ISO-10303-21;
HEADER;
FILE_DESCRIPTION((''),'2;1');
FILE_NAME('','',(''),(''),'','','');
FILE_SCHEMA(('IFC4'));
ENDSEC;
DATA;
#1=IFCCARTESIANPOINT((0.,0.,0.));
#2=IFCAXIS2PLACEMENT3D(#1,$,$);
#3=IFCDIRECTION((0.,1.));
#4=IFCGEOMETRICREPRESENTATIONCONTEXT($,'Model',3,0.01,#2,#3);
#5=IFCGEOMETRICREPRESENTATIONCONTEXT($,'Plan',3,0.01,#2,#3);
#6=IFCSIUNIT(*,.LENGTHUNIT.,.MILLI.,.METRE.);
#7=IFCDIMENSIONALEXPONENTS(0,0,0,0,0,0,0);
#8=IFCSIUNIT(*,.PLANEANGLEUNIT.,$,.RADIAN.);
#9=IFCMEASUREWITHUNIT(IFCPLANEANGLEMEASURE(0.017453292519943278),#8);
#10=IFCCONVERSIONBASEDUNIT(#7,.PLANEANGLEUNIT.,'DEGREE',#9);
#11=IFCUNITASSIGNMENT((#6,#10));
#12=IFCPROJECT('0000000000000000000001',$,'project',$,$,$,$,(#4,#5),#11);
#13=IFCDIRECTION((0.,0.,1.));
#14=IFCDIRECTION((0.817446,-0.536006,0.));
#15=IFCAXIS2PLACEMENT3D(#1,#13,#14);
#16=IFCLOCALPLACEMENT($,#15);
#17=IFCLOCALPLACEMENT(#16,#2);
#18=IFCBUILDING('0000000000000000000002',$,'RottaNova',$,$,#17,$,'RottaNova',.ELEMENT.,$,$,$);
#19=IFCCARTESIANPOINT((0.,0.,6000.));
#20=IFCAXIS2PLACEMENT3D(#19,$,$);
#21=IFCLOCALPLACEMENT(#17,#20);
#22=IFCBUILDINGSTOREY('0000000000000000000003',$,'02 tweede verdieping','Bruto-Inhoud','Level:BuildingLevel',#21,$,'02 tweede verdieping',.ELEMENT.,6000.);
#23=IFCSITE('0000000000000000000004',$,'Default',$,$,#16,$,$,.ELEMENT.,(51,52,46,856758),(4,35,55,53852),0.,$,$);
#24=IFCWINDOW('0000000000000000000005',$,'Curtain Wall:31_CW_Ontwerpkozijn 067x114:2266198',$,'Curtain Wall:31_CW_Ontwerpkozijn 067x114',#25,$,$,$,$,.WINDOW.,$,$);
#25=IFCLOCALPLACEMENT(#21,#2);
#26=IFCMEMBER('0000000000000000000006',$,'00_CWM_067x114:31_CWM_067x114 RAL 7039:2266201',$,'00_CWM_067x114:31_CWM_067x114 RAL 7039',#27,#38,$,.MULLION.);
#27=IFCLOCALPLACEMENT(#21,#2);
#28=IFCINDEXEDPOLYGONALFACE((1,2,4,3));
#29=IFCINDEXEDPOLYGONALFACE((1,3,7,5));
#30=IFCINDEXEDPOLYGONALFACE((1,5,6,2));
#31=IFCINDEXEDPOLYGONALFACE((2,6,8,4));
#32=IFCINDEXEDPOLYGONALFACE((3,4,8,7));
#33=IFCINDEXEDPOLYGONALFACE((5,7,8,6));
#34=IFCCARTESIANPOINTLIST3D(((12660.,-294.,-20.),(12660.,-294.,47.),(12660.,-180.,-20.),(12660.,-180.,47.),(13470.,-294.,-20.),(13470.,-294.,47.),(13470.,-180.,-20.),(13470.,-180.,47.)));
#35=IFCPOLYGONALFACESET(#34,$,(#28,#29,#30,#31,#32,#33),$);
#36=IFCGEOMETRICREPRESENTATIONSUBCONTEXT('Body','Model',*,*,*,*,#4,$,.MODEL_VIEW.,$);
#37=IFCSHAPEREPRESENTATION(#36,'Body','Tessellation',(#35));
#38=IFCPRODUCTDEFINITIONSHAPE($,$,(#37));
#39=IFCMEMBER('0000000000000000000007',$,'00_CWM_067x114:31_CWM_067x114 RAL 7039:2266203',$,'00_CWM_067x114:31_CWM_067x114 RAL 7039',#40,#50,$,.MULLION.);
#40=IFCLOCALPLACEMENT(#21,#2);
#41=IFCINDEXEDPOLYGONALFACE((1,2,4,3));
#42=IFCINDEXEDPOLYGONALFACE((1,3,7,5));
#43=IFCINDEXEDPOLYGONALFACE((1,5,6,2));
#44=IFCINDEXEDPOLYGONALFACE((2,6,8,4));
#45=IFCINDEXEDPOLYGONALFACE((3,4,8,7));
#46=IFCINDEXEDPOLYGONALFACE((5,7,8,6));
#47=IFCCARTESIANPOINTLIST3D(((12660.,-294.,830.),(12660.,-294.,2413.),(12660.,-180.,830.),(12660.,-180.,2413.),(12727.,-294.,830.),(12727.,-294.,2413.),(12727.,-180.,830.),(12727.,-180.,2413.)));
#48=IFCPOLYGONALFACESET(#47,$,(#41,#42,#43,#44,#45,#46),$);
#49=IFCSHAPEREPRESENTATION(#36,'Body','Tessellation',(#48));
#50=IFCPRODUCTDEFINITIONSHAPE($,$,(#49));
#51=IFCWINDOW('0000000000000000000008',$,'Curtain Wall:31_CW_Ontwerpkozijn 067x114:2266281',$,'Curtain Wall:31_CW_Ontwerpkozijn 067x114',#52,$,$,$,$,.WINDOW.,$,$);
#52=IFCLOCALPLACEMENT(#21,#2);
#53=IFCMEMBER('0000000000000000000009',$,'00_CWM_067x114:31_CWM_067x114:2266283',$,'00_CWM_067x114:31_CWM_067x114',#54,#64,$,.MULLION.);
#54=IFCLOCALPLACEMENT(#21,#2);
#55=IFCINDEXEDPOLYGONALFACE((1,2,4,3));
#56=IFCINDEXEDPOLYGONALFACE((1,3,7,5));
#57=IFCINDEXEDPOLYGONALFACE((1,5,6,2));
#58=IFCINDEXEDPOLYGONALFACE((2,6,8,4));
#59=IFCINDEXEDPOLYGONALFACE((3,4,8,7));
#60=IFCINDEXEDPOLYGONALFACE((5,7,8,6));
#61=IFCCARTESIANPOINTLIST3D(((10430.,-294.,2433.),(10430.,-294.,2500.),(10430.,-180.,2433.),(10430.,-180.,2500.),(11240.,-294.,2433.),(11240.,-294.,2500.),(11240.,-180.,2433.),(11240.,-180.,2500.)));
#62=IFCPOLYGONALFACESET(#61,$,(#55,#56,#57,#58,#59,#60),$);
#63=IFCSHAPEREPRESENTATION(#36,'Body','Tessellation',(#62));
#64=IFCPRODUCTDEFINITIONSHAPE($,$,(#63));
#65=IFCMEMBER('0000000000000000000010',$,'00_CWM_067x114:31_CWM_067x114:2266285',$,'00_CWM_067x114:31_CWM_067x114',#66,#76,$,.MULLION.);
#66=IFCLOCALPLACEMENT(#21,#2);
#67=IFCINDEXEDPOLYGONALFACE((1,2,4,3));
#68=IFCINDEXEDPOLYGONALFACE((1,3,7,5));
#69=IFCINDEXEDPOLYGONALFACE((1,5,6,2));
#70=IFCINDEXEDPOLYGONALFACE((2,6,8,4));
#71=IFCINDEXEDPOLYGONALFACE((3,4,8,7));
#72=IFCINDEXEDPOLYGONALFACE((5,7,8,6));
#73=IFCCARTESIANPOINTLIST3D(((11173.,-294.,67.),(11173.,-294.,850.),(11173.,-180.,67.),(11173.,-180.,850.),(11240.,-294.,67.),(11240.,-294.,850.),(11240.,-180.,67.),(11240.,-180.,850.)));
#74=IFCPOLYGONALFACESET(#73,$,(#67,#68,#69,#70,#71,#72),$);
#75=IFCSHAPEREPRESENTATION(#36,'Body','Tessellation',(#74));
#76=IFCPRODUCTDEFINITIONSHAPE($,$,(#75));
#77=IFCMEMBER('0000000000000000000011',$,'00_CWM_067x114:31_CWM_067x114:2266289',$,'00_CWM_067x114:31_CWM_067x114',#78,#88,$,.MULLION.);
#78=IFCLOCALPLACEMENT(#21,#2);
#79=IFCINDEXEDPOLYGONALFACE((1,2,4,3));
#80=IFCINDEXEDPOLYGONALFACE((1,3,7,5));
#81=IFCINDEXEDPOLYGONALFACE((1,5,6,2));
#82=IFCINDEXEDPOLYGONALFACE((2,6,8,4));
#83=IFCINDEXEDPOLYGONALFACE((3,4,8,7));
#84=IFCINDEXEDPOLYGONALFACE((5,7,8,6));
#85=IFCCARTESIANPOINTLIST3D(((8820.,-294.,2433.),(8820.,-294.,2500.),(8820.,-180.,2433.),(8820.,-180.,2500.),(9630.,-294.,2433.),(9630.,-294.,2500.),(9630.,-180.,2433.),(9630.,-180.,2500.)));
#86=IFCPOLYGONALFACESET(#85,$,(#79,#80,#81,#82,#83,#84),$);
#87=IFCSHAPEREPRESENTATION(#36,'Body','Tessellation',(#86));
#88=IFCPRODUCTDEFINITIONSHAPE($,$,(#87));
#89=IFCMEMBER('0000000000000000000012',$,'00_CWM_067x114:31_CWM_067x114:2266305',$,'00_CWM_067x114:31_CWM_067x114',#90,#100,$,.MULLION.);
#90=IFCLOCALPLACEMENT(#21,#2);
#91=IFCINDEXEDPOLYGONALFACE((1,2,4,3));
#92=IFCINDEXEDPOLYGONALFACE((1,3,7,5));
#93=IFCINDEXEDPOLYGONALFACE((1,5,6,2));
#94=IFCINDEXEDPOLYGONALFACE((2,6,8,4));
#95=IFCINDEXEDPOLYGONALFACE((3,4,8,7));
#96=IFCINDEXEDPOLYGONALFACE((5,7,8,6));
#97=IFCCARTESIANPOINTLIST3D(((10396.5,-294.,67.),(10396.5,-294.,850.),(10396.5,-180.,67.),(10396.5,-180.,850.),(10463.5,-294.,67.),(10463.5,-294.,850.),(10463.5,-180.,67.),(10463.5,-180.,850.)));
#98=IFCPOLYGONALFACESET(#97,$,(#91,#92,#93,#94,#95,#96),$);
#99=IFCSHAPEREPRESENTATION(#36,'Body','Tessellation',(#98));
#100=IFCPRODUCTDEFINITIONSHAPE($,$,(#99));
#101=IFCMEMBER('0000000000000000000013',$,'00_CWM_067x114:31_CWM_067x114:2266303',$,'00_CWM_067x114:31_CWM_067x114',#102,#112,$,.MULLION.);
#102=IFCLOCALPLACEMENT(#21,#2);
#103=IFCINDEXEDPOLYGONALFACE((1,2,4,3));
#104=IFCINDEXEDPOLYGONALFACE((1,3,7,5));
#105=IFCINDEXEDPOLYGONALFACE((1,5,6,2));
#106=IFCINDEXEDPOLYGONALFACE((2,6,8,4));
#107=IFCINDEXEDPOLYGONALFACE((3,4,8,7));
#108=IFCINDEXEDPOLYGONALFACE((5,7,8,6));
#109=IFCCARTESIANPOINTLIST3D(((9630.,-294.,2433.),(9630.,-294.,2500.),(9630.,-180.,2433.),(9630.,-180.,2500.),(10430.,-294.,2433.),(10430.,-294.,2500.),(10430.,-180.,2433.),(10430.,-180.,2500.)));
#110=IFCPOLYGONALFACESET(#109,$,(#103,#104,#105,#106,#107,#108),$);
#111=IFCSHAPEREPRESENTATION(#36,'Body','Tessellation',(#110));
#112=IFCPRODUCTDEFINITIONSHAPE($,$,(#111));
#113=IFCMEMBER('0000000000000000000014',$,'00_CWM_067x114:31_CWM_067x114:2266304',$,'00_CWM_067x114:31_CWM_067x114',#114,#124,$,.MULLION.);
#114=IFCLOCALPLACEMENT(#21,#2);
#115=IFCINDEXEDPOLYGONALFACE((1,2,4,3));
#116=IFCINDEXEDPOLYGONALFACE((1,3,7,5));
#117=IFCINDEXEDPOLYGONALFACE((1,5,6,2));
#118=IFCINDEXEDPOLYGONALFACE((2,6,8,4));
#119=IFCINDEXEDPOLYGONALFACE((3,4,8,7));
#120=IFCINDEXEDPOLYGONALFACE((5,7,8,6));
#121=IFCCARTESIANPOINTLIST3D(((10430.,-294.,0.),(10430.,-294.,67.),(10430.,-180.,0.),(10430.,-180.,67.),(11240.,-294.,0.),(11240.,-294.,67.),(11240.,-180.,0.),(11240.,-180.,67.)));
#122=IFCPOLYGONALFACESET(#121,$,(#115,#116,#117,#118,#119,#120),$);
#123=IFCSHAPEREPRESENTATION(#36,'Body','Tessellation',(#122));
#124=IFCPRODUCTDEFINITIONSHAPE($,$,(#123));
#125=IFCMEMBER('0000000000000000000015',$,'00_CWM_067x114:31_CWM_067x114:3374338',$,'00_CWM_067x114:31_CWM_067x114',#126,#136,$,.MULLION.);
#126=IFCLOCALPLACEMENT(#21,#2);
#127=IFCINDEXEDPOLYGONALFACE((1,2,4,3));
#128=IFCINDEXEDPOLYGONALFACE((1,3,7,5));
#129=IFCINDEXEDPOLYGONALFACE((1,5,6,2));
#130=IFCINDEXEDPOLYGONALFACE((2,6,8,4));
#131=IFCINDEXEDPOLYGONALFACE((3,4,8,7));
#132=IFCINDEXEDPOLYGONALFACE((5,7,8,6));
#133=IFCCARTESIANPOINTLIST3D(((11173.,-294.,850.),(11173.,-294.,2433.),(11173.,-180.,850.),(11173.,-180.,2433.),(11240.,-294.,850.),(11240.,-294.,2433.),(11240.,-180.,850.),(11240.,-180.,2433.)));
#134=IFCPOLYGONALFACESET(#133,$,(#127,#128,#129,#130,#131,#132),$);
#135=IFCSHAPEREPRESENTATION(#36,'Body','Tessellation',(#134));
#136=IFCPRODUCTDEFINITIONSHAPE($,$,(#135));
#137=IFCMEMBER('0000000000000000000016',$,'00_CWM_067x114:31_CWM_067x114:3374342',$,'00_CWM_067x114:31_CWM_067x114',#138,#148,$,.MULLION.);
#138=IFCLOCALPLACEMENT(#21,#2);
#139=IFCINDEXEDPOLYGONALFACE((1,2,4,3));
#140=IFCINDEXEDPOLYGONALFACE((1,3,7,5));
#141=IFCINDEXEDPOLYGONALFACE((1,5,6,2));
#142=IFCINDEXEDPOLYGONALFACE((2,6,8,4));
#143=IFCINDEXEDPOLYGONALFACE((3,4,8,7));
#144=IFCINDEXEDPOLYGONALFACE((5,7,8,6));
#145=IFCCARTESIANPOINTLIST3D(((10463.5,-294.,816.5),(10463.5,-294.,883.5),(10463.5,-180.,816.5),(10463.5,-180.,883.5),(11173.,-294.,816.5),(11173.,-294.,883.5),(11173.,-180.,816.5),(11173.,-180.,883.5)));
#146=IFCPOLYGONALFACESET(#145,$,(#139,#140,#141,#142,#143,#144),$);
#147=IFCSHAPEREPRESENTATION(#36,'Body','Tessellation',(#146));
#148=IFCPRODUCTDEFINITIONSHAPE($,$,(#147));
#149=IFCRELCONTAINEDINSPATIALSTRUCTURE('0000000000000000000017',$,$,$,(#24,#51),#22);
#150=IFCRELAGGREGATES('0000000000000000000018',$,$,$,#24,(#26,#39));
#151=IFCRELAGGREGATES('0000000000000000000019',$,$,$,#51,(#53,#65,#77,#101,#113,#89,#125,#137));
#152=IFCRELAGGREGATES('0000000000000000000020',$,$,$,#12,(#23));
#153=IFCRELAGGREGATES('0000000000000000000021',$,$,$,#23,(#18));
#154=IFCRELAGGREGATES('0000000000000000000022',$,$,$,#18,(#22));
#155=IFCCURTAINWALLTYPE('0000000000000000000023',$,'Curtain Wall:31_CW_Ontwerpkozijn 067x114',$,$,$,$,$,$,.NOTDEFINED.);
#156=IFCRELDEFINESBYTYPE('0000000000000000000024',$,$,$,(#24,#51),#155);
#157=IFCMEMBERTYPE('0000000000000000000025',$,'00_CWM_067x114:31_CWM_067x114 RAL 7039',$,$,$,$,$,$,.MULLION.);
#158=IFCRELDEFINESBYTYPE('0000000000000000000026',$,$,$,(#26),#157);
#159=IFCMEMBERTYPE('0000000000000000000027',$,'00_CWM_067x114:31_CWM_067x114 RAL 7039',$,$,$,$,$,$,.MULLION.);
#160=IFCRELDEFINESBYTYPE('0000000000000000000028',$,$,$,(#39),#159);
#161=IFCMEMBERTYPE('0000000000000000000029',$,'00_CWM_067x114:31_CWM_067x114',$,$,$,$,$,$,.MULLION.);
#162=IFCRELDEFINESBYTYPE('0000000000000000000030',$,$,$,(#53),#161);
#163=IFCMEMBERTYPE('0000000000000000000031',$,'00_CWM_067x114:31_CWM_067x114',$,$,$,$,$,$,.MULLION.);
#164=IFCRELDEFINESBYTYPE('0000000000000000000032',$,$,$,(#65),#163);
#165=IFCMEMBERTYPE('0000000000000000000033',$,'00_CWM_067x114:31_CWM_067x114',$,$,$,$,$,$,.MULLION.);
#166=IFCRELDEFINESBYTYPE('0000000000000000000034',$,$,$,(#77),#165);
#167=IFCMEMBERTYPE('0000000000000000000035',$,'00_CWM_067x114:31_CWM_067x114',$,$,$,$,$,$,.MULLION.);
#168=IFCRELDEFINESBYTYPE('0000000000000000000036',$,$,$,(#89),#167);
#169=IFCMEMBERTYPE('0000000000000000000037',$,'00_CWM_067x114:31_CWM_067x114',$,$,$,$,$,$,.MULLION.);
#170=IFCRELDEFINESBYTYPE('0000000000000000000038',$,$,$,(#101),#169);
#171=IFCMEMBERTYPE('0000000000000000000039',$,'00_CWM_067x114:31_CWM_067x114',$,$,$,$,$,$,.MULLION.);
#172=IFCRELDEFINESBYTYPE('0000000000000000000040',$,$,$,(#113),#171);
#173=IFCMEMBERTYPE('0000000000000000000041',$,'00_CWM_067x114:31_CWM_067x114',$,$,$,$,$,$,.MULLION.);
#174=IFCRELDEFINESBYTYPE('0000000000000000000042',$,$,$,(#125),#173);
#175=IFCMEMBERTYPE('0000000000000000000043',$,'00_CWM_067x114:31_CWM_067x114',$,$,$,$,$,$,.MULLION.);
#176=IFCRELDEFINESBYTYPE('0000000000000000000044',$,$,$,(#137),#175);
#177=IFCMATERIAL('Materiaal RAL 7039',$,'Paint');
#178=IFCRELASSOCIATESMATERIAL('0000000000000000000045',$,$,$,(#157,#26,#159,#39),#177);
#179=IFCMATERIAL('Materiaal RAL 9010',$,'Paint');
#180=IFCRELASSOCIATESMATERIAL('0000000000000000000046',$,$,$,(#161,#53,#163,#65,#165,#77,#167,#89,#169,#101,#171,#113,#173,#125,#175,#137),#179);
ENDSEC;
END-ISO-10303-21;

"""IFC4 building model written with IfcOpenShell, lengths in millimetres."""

from ifc_helpers import new_model, entity, si_unit, converted_unit, direction, frame, origin, place, context, subcontext, project, spatial, indexed_curve, outline, extrude, source, transform, mapped, material, type_object, type_shapes, element, aggregate, save


model = new_model("IFC4")

# Units and contexts
model_context = context("Model", 3, precision=0.01, world=origin(), true_north=direction((0.0, 1.0)))
plan_context = context("Plan", 3, precision=0.01, world=origin(), true_north=direction((0.0, 1.0)))
body_context = subcontext(model_context, "Body", "Model", "MODEL_VIEW")
ifc_project = project(units=[si_unit("LENGTHUNIT", "METRE", prefix="MILLI"), converted_unit("PLANEANGLEUNIT", "DEGREE", entity("IfcPlaneAngleMeasure", 0.017453292519943278), si_unit("PLANEANGLEUNIT", "RADIAN"), dimensions=[0, 0, 0, 0, 0, 0, 0])], contexts=[model_context, plan_context])

# Site, building, storey
site_placement = place(None, frame((0.0, 0.0, 0.0), z_axis=(0.0, 0.0, 1.0), x_axis=(0.817446, -0.536006, 0.0)))
site = spatial("IfcSite", under=ifc_project, at=site_placement, Name="Default", CompositionType="ELEMENT", RefLatitude=(51, 52, 46, 856758), RefLongitude=(4, 35, 55, 53852), RefElevation=0.0)
building_placement = place(site_placement, origin())
building = spatial("IfcBuilding", under=site, at=building_placement, Name="RottaNova", LongName="RottaNova", CompositionType="ELEMENT")
storey_placement = place(building_placement, frame((0.0, 0.0, 6000.0)))
storey = spatial("IfcBuildingStorey", under=building, at=storey_placement, Name="02 tweede verdieping", Description="Bruto-Inhoud", ObjectType="Level:BuildingLevel", LongName="02 tweede verdieping", CompositionType="ELEMENT", Elevation=6000.0)

# Window, members
curtain_wall_type = type_object("IfcCurtainWallType", Name="Curtain Wall:31_CW_Ontwerpkozijn 067x114", PredefinedType="NOTDEFINED")
window_1_placement = place(storey_placement, frame((0.0, 0.0, -6000.0)))
window_1 = element("IfcWindow", 1, at=window_1_placement, inside=storey, type_object=curtain_wall_type, Name="Curtain Wall:31_CW_Ontwerpkozijn 067x114:2266198", ObjectType="Curtain Wall:31_CW_Ontwerpkozijn 067x114", PredefinedType="WINDOW")
ifc_material_1 = material(Name="Materiaal RAL 7039", Category="Paint")
member_type_1 = type_object("IfcMemberType", Name="00_CWM_067x114:31_CWM_067x114 RAL 7039", PredefinedType="MULLION", material=ifc_material_1)
shared_shape_1 = source(origin(), body_context, "Body", "SweptSolid", [
    extrude(outline(indexed_curve([(-33.5, -57.0), (33.5, -57.0), (33.5, 57.0), (-33.5, 57.0), (-33.5, -57.0)], self_intersect=False)), frame((-33.5, 57.0, -810.0), z_axis=(0.0, 0.0, 1.0), x_axis=(-1.0, 0.0, 0.0)), (0.0, 0.0, 1.0), 810.0),
])
type_shapes(member_type_1, [shared_shape_1])
member_1_placement = place(window_1_placement, frame((12660.0, -180.0, 5980.0), z_axis=(-1.0, 0.0, 0.0), x_axis=(0.0, 0.0, -1.0)))
member_1 = element("IfcMember", 2, at=member_1_placement, type_object=member_type_1, material=ifc_material_1, Name="00_CWM_067x114:31_CWM_067x114 RAL 7039:2266201", ObjectType="00_CWM_067x114:31_CWM_067x114 RAL 7039", PredefinedType="MULLION", context=body_context, shape_type="MappedRepresentation", body=[
    mapped(shared_shape_1, transform((0.0, 0.0, 0.0), scale=1.0)),
])
member_type_2 = type_object("IfcMemberType", Name="00_CWM_067x114:31_CWM_067x114 RAL 7039", PredefinedType="MULLION", material=ifc_material_1)
shared_shape_2 = source(origin(), body_context, "Body", "SweptSolid", [
    extrude(outline(indexed_curve([(-33.5, -57.0), (33.5, -57.0), (33.5, 57.0), (-33.5, 57.0), (-33.5, -57.0)], self_intersect=False)), frame((-33.5, 57.0, -1583.0), z_axis=(0.0, 0.0, 1.0), x_axis=(-1.0, 0.0, 0.0)), (0.0, 0.0, 1.0), 1583.0),
])
type_shapes(member_type_2, [shared_shape_2])
member_2_placement = place(window_1_placement, frame((12660.0, -180.0, 8413.0), z_axis=(0.0, 0.0, 1.0), x_axis=(-1.0, 0.0, 0.0)))
member_2 = element("IfcMember", 3, at=member_2_placement, type_object=member_type_2, material=ifc_material_1, Name="00_CWM_067x114:31_CWM_067x114 RAL 7039:2266203", ObjectType="00_CWM_067x114:31_CWM_067x114 RAL 7039", PredefinedType="MULLION", context=body_context, shape_type="MappedRepresentation", body=[
    mapped(shared_shape_2, transform((0.0, 0.0, 0.0), scale=1.0)),
])
aggregate(window_1, [member_1, member_2])

# Window, members
window_2_placement = place(storey_placement, frame((0.0, 0.0, -6000.0)))
window_2 = element("IfcWindow", 4, at=window_2_placement, inside=storey, type_object=curtain_wall_type, Name="Curtain Wall:31_CW_Ontwerpkozijn 067x114:2266281", ObjectType="Curtain Wall:31_CW_Ontwerpkozijn 067x114", PredefinedType="WINDOW")
ifc_material_2 = material(Name="Materiaal RAL 9010", Category="Paint")
member_type_3 = type_object("IfcMemberType", Name="00_CWM_067x114:31_CWM_067x114", PredefinedType="MULLION", material=ifc_material_2)
shared_shape_3 = source(origin(), body_context, "Body", "SweptSolid", [
    extrude(outline(indexed_curve([(-33.5, -57.0), (33.5, -57.0), (33.5, 57.0), (-33.5, 57.0), (-33.5, -57.0)], self_intersect=False)), frame((-33.5, 57.0, -810.0), z_axis=(0.0, 0.0, 1.0), x_axis=(-1.0, 0.0, 0.0)), (0.0, 0.0, 1.0), 810.0),
])
type_shapes(member_type_3, [shared_shape_3])
member_3_placement = place(window_2_placement, frame((11240.0, -180.0, 8500.0), z_axis=(1.0, 0.0, 0.0), x_axis=(0.0, 0.0, 1.0)))
member_3 = element("IfcMember", 5, at=member_3_placement, type_object=member_type_3, material=ifc_material_2, Name="00_CWM_067x114:31_CWM_067x114:2266283", ObjectType="00_CWM_067x114:31_CWM_067x114", PredefinedType="MULLION", context=body_context, shape_type="MappedRepresentation", body=[
    mapped(shared_shape_3, transform((0.0, 0.0, 0.0), scale=1.0)),
])
member_type_4 = type_object("IfcMemberType", Name="00_CWM_067x114:31_CWM_067x114", PredefinedType="MULLION", material=ifc_material_2)
shared_shape_4 = source(origin(), body_context, "Body", "SweptSolid", [
    extrude(outline(indexed_curve([(-33.5, -57.0), (33.5, -57.0), (33.5, 57.0), (-33.5, 57.0), (-33.5, -57.0)], self_intersect=False)), frame((-33.5, 57.0, -783.0), z_axis=(0.0, 0.0, 1.0), x_axis=(-1.0, 0.0, 0.0)), (0.0, 0.0, 1.0), 783.0),
])
type_shapes(member_type_4, [shared_shape_4])
member_4_placement = place(window_2_placement, frame((11240.0, -180.0, 6067.0), z_axis=(0.0, 0.0, -1.0), x_axis=(1.0, 0.0, 0.0)))
member_4 = element("IfcMember", 6, at=member_4_placement, type_object=member_type_4, material=ifc_material_2, Name="00_CWM_067x114:31_CWM_067x114:2266285", ObjectType="00_CWM_067x114:31_CWM_067x114", PredefinedType="MULLION", context=body_context, shape_type="MappedRepresentation", body=[
    mapped(shared_shape_4, transform((0.0, 0.0, 0.0), scale=1.0)),
])
member_type_5 = type_object("IfcMemberType", Name="00_CWM_067x114:31_CWM_067x114", PredefinedType="MULLION", material=ifc_material_2)
shared_shape_5 = source(origin(), body_context, "Body", "SweptSolid", [
    extrude(outline(indexed_curve([(-33.5, -57.0), (33.5, -57.0), (33.5, 57.0), (-33.5, 57.0), (-33.5, -57.0)], self_intersect=False)), frame((-33.5, 57.0, -810.0), z_axis=(0.0, 0.0, 1.0), x_axis=(-1.0, 0.0, 0.0)), (0.0, 0.0, 1.0), 810.0),
])
type_shapes(member_type_5, [shared_shape_5])
member_5_placement = place(window_2_placement, frame((9630.0, -180.0, 8500.0), z_axis=(1.0, 0.0, 0.0), x_axis=(0.0, 0.0, 1.0)))
member_5 = element("IfcMember", 7, at=member_5_placement, type_object=member_type_5, material=ifc_material_2, Name="00_CWM_067x114:31_CWM_067x114:2266289", ObjectType="00_CWM_067x114:31_CWM_067x114", PredefinedType="MULLION", context=body_context, shape_type="MappedRepresentation", body=[
    mapped(shared_shape_5, transform((0.0, 0.0, 0.0), scale=1.0)),
])
member_type_6 = type_object("IfcMemberType", Name="00_CWM_067x114:31_CWM_067x114", PredefinedType="MULLION", material=ifc_material_2)
shared_shape_6 = source(origin(), body_context, "Body", "SweptSolid", [
    extrude(outline(indexed_curve([(-33.5, -57.0), (33.5, -57.0), (33.5, 57.0), (-33.5, 57.0), (-33.5, -57.0)], self_intersect=False)), frame((0.0, 57.0, -783.0), z_axis=(0.0, 0.0, 1.0), x_axis=(-1.0, 0.0, 0.0)), (0.0, 0.0, 1.0), 783.0),
])
type_shapes(member_type_6, [shared_shape_6])
member_6_placement = place(window_2_placement, frame((10430.0, -180.0, 6067.0), z_axis=(0.0, 0.0, -1.0), x_axis=(1.0, 0.0, 0.0)))
member_6 = element("IfcMember", 8, at=member_6_placement, type_object=member_type_6, material=ifc_material_2, Name="00_CWM_067x114:31_CWM_067x114:2266305", ObjectType="00_CWM_067x114:31_CWM_067x114", PredefinedType="MULLION", context=body_context, shape_type="MappedRepresentation", body=[
    mapped(shared_shape_6, transform((0.0, 0.0, 0.0), scale=1.0)),
])
member_type_7 = type_object("IfcMemberType", Name="00_CWM_067x114:31_CWM_067x114", PredefinedType="MULLION", material=ifc_material_2)
shared_shape_7 = source(origin(), body_context, "Body", "SweptSolid", [
    extrude(outline(indexed_curve([(-33.5, -57.0), (33.5, -57.0), (33.5, 57.0), (-33.5, 57.0), (-33.5, -57.0)], self_intersect=False)), frame((-33.5, 57.0, -800.0), z_axis=(0.0, 0.0, 1.0), x_axis=(-1.0, 0.0, 0.0)), (0.0, 0.0, 1.0), 800.0),
])
type_shapes(member_type_7, [shared_shape_7])
member_7_placement = place(window_2_placement, frame((10430.0, -180.0, 8500.0), z_axis=(1.0, 0.0, 0.0), x_axis=(0.0, 0.0, 1.0)))
member_7 = element("IfcMember", 9, at=member_7_placement, type_object=member_type_7, material=ifc_material_2, Name="00_CWM_067x114:31_CWM_067x114:2266303", ObjectType="00_CWM_067x114:31_CWM_067x114", PredefinedType="MULLION", context=body_context, shape_type="MappedRepresentation", body=[
    mapped(shared_shape_7, transform((0.0, 0.0, 0.0), scale=1.0)),
])
member_type_8 = type_object("IfcMemberType", Name="00_CWM_067x114:31_CWM_067x114", PredefinedType="MULLION", material=ifc_material_2)
shared_shape_8 = source(origin(), body_context, "Body", "SweptSolid", [
    extrude(outline(indexed_curve([(-33.5, -57.0), (33.5, -57.0), (33.5, 57.0), (-33.5, 57.0), (-33.5, -57.0)], self_intersect=False)), frame((-33.5, 57.0, -810.0), z_axis=(0.0, 0.0, 1.0), x_axis=(-1.0, 0.0, 0.0)), (0.0, 0.0, 1.0), 810.0),
])
type_shapes(member_type_8, [shared_shape_8])
member_8_placement = place(window_2_placement, frame((10430.0, -180.0, 6000.0), z_axis=(-1.0, 0.0, 0.0), x_axis=(0.0, 0.0, -1.0)))
member_8 = element("IfcMember", 10, at=member_8_placement, type_object=member_type_8, material=ifc_material_2, Name="00_CWM_067x114:31_CWM_067x114:2266304", ObjectType="00_CWM_067x114:31_CWM_067x114", PredefinedType="MULLION", context=body_context, shape_type="MappedRepresentation", body=[
    mapped(shared_shape_8, transform((0.0, 0.0, 0.0), scale=1.0)),
])
member_type_9 = type_object("IfcMemberType", Name="00_CWM_067x114:31_CWM_067x114", PredefinedType="MULLION", material=ifc_material_2)
shared_shape_9 = source(origin(), body_context, "Body", "SweptSolid", [
    extrude(outline(indexed_curve([(-33.5, -57.0), (33.5, -57.0), (33.5, 57.0), (-33.5, 57.0), (-33.5, -57.0)], self_intersect=False)), frame((-33.5, 57.0, -1583.0), z_axis=(0.0, 0.0, 1.0), x_axis=(-1.0, 0.0, 0.0)), (0.0, 0.0, 1.0), 1583.0),
])
type_shapes(member_type_9, [shared_shape_9])
member_9_placement = place(window_2_placement, frame((11240.0, -180.0, 6850.0), z_axis=(0.0, 0.0, -1.0), x_axis=(1.0, 0.0, 0.0)))
member_9 = element("IfcMember", 11, at=member_9_placement, type_object=member_type_9, material=ifc_material_2, Name="00_CWM_067x114:31_CWM_067x114:3374338", ObjectType="00_CWM_067x114:31_CWM_067x114", PredefinedType="MULLION", context=body_context, shape_type="MappedRepresentation", body=[
    mapped(shared_shape_9, transform((0.0, 0.0, 0.0), scale=1.0)),
])
member_type_10 = type_object("IfcMemberType", Name="00_CWM_067x114:31_CWM_067x114", PredefinedType="MULLION", material=ifc_material_2)
shared_shape_10 = source(origin(), body_context, "Body", "SweptSolid", [
    extrude(outline(indexed_curve([(-33.5, -57.0), (33.5, -57.0), (33.5, 57.0), (-33.5, 57.0), (-33.5, -57.0)], self_intersect=False)), frame((0.0, 57.0, -709.5), z_axis=(0.0, 0.0, 1.0), x_axis=(-1.0, 0.0, 0.0)), (0.0, 0.0, 1.0), 709.5),
])
type_shapes(member_type_10, [shared_shape_10])
member_10_placement = place(window_2_placement, frame((11173.0, -180.0, 6850.0), z_axis=(1.0, 0.0, 0.0), x_axis=(0.0, 0.0, 1.0)))
member_10 = element("IfcMember", 12, at=member_10_placement, type_object=member_type_10, material=ifc_material_2, Name="00_CWM_067x114:31_CWM_067x114:3374342", ObjectType="00_CWM_067x114:31_CWM_067x114", PredefinedType="MULLION", context=body_context, shape_type="MappedRepresentation", body=[
    mapped(shared_shape_10, transform((0.0, 0.0, 0.0), scale=1.0)),
])
aggregate(window_2, [member_3, member_4, member_5, member_7, member_8, member_6, member_9, member_10])

save(model, "model.ifc")
